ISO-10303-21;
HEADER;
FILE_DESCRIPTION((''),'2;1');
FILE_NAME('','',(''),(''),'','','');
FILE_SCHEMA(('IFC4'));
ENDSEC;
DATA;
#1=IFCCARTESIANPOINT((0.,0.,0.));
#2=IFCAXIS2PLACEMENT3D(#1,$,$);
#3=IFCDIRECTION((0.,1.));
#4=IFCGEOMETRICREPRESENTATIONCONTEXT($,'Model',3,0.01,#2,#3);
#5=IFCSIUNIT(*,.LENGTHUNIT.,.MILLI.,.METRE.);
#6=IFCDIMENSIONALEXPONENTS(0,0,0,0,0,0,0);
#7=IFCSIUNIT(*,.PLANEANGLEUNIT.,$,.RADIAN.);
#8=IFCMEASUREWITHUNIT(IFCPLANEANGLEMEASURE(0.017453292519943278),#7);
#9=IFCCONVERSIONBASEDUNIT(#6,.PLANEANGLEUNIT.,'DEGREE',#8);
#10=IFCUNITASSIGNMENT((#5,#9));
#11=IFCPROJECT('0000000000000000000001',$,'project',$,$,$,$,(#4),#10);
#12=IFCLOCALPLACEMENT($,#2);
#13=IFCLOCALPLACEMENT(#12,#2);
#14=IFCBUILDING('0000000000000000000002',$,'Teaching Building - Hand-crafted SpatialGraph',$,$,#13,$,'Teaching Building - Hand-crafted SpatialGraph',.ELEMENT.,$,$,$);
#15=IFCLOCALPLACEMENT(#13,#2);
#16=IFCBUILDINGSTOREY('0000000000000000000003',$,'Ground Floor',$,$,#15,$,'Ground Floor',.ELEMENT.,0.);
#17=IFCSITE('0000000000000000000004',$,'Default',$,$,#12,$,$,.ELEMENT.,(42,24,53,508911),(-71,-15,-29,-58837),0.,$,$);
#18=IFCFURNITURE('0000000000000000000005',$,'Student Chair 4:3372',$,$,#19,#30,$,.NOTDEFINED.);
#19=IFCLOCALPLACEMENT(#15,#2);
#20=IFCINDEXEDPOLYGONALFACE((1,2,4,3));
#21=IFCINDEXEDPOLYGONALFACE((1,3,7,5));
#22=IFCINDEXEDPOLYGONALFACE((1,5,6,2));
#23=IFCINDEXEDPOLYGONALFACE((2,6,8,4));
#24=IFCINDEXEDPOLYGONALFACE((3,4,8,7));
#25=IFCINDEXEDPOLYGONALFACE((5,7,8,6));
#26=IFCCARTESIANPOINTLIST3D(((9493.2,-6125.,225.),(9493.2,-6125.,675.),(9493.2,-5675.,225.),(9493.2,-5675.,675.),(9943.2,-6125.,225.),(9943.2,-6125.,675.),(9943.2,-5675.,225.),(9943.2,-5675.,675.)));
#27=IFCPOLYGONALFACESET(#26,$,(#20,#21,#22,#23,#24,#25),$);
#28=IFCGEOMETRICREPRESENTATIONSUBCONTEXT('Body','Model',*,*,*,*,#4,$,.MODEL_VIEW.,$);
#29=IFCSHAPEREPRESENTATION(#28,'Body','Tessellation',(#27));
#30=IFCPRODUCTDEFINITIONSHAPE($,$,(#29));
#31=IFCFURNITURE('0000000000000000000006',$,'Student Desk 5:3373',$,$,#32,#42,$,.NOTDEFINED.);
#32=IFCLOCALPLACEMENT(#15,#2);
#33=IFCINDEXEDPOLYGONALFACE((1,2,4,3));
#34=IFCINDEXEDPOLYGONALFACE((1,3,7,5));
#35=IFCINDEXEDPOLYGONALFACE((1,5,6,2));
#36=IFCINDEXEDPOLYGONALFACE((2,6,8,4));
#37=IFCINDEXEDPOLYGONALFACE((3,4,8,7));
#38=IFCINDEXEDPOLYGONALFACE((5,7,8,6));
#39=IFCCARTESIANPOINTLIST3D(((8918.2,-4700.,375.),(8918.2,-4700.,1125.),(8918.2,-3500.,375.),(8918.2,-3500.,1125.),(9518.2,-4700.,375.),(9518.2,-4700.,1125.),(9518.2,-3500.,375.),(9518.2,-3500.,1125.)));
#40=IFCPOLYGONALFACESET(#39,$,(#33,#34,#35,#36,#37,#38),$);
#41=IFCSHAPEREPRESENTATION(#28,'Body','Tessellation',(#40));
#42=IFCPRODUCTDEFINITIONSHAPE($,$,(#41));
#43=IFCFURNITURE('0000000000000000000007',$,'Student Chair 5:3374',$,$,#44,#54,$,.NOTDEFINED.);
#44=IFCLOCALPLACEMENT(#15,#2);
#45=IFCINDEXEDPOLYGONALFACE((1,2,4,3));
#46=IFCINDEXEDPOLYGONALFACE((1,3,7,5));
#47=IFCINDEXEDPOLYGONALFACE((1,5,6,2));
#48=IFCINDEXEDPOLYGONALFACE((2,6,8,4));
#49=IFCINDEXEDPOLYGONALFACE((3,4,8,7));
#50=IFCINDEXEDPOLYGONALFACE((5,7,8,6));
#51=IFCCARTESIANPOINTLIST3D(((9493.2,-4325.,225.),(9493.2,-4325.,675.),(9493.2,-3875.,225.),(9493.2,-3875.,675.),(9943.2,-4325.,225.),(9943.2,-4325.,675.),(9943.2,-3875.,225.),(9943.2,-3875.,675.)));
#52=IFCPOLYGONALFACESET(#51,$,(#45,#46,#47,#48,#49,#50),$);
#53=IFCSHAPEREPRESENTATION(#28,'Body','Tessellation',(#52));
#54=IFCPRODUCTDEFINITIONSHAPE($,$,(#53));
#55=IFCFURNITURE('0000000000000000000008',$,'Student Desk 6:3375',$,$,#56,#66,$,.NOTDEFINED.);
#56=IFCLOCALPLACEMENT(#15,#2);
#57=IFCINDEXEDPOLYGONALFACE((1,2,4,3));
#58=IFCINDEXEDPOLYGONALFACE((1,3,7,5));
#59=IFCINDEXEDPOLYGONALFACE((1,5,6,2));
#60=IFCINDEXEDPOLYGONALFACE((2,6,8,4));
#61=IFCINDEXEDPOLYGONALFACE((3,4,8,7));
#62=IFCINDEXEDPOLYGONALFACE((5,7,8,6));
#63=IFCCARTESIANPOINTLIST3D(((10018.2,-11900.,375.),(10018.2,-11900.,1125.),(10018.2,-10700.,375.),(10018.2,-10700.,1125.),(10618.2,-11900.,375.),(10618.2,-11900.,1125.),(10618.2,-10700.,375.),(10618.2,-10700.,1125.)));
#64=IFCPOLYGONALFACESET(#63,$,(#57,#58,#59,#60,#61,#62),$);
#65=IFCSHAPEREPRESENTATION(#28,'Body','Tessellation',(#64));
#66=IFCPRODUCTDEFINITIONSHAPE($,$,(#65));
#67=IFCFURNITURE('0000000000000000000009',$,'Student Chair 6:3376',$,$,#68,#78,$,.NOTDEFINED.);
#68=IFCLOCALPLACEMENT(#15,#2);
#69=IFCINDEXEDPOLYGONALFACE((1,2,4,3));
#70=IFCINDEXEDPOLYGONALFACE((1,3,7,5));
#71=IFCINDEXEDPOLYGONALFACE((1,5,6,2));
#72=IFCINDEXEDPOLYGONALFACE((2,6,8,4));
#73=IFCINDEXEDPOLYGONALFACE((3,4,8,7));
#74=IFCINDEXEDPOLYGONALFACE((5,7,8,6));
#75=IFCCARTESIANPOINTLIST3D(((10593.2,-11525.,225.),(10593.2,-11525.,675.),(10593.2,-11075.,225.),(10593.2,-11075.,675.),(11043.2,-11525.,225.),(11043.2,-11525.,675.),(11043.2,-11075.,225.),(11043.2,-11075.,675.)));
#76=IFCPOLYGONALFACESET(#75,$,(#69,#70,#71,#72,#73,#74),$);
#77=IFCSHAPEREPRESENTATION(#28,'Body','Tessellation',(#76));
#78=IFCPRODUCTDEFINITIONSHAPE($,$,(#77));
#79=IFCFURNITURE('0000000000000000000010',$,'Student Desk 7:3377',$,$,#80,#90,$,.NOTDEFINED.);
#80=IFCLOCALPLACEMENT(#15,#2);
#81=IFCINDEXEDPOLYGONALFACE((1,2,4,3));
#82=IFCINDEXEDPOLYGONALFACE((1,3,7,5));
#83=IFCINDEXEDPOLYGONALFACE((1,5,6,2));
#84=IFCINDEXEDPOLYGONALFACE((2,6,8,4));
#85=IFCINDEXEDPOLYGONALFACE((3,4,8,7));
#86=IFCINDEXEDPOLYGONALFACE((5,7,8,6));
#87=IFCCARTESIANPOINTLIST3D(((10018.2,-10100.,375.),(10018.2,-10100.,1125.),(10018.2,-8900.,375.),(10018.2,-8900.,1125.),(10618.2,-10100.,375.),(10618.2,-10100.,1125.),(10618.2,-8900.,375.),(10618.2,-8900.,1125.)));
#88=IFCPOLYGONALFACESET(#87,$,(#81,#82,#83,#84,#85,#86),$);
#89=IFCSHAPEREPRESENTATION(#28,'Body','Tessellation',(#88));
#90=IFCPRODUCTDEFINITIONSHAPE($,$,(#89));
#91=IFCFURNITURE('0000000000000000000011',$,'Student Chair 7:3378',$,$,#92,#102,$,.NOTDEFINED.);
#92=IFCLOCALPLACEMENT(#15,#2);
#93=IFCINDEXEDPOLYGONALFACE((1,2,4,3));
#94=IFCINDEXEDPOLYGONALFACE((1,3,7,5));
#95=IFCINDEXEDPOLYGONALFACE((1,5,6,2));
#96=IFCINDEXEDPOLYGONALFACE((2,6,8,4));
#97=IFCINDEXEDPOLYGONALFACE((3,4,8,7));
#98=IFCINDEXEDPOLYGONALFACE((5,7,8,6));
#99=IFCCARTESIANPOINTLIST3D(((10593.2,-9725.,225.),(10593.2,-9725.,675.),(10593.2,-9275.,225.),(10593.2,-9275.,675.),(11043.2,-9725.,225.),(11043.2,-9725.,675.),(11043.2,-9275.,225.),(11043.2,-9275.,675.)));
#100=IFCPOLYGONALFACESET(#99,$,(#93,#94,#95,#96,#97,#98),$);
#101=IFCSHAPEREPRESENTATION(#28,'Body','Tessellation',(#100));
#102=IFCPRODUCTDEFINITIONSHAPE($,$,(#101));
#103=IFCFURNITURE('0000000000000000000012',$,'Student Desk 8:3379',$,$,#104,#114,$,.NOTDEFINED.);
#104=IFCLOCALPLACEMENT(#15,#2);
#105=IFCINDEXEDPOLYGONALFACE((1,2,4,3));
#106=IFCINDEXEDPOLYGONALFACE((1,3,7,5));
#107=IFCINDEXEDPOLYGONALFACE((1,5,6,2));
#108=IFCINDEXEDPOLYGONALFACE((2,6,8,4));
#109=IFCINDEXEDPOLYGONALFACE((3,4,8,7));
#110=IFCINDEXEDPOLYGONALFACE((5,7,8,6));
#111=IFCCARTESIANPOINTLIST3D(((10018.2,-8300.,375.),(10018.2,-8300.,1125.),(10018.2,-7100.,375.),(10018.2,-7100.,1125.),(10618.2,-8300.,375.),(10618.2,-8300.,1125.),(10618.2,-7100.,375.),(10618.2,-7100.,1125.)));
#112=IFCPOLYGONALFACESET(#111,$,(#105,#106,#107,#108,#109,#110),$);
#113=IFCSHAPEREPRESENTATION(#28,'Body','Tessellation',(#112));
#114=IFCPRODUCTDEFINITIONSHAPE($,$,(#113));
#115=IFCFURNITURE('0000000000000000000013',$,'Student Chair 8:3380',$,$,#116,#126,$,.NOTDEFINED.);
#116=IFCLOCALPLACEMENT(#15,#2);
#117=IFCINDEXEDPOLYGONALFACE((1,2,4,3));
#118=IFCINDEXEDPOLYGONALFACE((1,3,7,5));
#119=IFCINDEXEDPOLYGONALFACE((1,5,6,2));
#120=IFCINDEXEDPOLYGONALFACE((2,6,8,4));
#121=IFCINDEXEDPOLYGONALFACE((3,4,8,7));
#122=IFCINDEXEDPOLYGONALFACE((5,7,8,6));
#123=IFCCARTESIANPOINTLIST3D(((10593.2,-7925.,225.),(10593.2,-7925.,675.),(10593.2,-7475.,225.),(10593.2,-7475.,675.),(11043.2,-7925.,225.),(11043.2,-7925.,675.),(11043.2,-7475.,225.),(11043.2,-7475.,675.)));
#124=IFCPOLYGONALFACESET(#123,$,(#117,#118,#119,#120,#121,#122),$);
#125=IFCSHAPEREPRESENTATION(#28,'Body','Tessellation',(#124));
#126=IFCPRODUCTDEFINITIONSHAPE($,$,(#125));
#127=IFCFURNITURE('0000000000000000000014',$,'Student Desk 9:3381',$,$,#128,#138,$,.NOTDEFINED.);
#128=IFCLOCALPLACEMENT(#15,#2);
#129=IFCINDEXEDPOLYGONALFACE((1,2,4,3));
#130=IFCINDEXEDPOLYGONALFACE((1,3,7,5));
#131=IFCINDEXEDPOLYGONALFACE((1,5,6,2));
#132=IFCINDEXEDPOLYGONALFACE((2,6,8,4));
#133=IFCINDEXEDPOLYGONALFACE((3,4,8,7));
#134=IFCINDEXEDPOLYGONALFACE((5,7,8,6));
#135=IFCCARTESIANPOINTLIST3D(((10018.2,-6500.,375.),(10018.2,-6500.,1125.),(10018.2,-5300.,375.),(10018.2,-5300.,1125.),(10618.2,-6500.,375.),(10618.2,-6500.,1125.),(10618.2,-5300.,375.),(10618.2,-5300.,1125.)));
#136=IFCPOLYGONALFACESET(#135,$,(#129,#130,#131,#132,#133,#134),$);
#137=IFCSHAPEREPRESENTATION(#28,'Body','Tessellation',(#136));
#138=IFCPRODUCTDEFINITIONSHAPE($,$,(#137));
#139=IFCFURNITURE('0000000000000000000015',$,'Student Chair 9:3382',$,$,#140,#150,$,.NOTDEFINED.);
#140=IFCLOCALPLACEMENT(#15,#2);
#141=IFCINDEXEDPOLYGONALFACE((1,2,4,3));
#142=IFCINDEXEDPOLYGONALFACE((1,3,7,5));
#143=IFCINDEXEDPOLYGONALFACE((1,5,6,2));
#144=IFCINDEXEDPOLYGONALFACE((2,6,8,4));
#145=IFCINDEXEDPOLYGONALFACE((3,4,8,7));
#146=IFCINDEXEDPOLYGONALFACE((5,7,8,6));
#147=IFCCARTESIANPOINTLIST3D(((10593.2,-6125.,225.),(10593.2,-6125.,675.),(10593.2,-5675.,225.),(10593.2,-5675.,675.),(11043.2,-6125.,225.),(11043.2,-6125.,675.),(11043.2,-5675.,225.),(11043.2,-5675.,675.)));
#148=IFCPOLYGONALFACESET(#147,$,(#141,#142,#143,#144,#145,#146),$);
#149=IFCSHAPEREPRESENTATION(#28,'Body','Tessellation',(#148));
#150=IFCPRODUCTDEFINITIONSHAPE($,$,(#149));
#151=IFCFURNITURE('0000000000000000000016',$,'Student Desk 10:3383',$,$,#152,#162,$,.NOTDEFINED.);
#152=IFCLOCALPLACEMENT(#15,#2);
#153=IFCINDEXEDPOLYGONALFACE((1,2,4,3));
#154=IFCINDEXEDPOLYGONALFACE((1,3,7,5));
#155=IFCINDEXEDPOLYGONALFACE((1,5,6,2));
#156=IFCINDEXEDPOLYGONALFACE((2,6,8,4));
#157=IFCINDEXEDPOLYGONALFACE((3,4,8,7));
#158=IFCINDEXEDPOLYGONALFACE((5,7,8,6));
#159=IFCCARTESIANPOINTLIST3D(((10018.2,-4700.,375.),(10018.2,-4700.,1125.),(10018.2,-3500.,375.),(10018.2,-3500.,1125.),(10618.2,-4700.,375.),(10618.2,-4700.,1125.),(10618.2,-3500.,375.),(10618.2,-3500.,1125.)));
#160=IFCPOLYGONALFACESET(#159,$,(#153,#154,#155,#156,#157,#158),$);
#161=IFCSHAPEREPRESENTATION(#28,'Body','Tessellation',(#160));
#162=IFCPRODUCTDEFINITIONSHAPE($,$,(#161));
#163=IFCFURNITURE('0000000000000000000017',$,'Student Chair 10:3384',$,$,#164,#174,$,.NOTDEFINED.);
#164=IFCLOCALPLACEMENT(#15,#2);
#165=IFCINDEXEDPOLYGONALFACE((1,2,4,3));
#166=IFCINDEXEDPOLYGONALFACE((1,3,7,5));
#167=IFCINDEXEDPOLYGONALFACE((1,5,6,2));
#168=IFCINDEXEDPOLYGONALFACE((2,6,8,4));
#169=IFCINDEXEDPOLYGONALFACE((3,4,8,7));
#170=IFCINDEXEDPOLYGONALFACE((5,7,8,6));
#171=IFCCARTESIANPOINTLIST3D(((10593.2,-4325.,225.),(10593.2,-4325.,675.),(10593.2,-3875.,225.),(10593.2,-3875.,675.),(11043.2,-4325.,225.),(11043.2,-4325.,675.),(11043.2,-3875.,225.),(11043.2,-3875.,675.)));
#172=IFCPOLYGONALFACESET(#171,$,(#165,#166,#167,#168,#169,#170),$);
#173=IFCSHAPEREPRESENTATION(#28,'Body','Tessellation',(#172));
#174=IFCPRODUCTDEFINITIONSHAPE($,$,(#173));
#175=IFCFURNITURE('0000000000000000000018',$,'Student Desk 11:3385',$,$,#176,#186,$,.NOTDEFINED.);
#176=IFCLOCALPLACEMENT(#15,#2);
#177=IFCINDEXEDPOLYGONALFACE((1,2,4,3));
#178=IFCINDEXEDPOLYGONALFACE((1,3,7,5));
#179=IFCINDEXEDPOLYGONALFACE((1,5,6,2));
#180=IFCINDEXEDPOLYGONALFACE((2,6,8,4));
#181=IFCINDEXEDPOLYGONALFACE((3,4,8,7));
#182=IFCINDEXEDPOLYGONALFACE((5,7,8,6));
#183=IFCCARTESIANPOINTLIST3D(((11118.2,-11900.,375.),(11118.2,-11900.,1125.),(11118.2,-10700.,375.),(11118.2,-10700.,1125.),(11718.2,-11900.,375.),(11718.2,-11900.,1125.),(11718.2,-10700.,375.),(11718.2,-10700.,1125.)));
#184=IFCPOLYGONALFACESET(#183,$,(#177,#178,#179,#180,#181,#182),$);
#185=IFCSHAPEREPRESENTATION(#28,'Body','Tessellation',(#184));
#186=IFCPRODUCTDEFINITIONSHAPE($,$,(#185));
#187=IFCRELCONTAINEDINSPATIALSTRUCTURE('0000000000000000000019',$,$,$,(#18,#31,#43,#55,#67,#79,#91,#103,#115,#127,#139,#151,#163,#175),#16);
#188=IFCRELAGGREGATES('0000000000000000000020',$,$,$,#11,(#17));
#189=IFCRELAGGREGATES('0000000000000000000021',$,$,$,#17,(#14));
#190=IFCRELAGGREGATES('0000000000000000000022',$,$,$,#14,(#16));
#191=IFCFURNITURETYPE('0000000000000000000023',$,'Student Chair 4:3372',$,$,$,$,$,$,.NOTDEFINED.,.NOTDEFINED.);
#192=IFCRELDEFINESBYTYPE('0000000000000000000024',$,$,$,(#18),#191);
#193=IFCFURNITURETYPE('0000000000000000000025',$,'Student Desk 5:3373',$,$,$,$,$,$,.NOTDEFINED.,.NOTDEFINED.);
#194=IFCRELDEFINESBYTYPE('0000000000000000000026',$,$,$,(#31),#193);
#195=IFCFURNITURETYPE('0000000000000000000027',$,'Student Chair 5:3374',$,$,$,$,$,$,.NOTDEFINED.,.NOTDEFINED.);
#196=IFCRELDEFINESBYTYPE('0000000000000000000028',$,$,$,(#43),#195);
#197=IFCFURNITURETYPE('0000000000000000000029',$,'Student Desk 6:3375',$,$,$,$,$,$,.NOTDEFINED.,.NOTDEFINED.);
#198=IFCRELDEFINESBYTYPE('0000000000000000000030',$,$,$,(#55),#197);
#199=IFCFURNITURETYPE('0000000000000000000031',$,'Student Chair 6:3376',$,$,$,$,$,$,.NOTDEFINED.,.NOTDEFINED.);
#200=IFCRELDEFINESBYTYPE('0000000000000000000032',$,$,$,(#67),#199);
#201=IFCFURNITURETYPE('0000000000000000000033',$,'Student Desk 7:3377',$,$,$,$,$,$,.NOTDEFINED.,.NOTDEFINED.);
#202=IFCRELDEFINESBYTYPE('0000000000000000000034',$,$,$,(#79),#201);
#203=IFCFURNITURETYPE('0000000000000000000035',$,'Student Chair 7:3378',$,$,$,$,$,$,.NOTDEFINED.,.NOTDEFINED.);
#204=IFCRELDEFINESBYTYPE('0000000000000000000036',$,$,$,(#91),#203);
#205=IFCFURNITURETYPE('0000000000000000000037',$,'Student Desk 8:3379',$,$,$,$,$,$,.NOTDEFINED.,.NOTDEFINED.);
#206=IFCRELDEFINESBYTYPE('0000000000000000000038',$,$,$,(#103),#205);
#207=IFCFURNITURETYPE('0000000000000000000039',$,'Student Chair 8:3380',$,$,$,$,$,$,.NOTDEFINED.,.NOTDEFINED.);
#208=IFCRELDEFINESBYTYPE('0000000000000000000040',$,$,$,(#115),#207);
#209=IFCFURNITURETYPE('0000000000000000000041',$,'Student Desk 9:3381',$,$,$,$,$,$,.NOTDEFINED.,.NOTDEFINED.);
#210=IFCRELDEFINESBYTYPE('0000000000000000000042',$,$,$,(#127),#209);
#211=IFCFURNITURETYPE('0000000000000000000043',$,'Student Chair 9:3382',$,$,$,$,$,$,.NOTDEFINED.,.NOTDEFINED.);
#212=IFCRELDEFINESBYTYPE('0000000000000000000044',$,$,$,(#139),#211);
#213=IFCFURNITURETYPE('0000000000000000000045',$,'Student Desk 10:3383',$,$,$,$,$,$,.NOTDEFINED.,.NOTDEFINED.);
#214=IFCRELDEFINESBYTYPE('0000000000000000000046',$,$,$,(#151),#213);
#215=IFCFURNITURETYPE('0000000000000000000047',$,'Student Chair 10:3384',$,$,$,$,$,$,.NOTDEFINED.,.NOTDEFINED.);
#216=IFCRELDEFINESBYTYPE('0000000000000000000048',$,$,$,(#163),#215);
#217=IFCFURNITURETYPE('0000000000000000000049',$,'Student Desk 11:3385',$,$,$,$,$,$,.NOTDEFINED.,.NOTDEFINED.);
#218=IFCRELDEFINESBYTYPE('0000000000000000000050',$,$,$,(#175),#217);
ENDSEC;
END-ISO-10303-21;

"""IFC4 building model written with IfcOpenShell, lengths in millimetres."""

from ifc_helpers import new_model, entity, si_unit, converted_unit, direction, frame, frame_2d, origin, origin_2d_with_axis, place, context, subcontext, project, spatial, rectangle, extrude, type_object, element, save


model = new_model("IFC4")

# Units and contexts
model_context = context("Model", 3, precision=0.01, world=origin(), true_north=direction((0.0, 1.0)))
body_context = subcontext(model_context, "Body", "Model", "MODEL_VIEW")
ifc_project = project(units=[si_unit("LENGTHUNIT", "METRE", prefix="MILLI"), converted_unit("PLANEANGLEUNIT", "DEGREE", entity("IfcPlaneAngleMeasure", 0.017453292519943278), si_unit("PLANEANGLEUNIT", "RADIAN"), dimensions=[0, 0, 0, 0, 0, 0, 0])], contexts=[model_context])

# Site, building, storey
site_placement = place(None, origin())
site = spatial("IfcSite", under=ifc_project, at=site_placement, Name="Default", CompositionType="ELEMENT", RefLatitude=(42, 24, 53, 508911), RefLongitude=(-71, -15, -29, -58837), RefElevation=0.0)
building_placement = place(site_placement, origin())
building = spatial("IfcBuilding", under=site, at=building_placement, Name="Teaching Building - Hand-crafted SpatialGraph", LongName="Teaching Building - Hand-crafted SpatialGraph", CompositionType="ELEMENT")
storey_placement = place(building_placement, origin())
storey = spatial("IfcBuildingStorey", under=building, at=storey_placement, Name="Ground Floor", LongName="Ground Floor", CompositionType="ELEMENT", Elevation=0.0)

# Furniture
furniture_type_1 = type_object("IfcFurnitureType", Name="Student Chair 4:3372", PredefinedType="NOTDEFINED")
furniture_1_placement = place(storey_placement, origin())
element("IfcFurniture", 1, at=furniture_1_placement, inside=storey, type_object=furniture_type_1, Name="Student Chair 4:3372", PredefinedType="NOTDEFINED", context=body_context, shape_type="SweptSolid", body=[
    extrude(rectangle(XDim=450.0, YDim=450.0, at=frame_2d((0.0, 0.0), x_axis=(1.0, 0.0))), frame((9718.2, -5900.0, 225.0)), (0.0, 0.0, 1.0), 450.0),
])
furniture_type_2 = type_object("IfcFurnitureType", Name="Student Desk 5:3373", PredefinedType="NOTDEFINED")
furniture_2_placement = place(storey_placement, origin())
element("IfcFurniture", 2, at=furniture_2_placement, inside=storey, type_object=furniture_type_2, Name="Student Desk 5:3373", PredefinedType="NOTDEFINED", context=body_context, shape_type="SweptSolid", body=[
    extrude(rectangle(XDim=1200.0, YDim=600.0, at=frame_2d((0.0, 0.0), x_axis=(1.0, 0.0))), frame((9218.2, -4100.0, 375.0), z_axis=(0.0, 0.0, 1.0), x_axis=(0.0, 1.0, 0.0)), (0.0, 0.0, 1.0), 750.0),
])
furniture_type_3 = type_object("IfcFurnitureType", Name="Student Chair 5:3374", PredefinedType="NOTDEFINED")
furniture_3_placement = place(storey_placement, origin())
element("IfcFurniture", 3, at=furniture_3_placement, inside=storey, type_object=furniture_type_3, Name="Student Chair 5:3374", PredefinedType="NOTDEFINED", context=body_context, shape_type="SweptSolid", body=[
    extrude(rectangle(XDim=450.0, YDim=450.0, at=frame_2d((0.0, 0.0), x_axis=(1.0, 0.0))), frame((9718.2, -4100.0, 225.0)), (0.0, 0.0, 1.0), 450.0),
])
furniture_type_4 = type_object("IfcFurnitureType", Name="Student Desk 6:3375", PredefinedType="NOTDEFINED")
furniture_4_placement = place(storey_placement, origin())
element("IfcFurniture", 4, at=furniture_4_placement, inside=storey, type_object=furniture_type_4, Name="Student Desk 6:3375", PredefinedType="NOTDEFINED", context=body_context, shape_type="SweptSolid", body=[
    extrude(rectangle(XDim=1200.0, YDim=600.0, at=origin_2d_with_axis()), frame((10318.2, -11300.0, 375.0), z_axis=(0.0, 0.0, 1.0), x_axis=(0.0, 1.0, 0.0)), (0.0, 0.0, 1.0), 750.0),
])
furniture_type_5 = type_object("IfcFurnitureType", Name="Student Chair 6:3376", PredefinedType="NOTDEFINED")
furniture_5_placement = place(storey_placement, origin())
element("IfcFurniture", 5, at=furniture_5_placement, inside=storey, type_object=furniture_type_5, Name="Student Chair 6:3376", PredefinedType="NOTDEFINED", context=body_context, shape_type="SweptSolid", body=[
    extrude(rectangle(XDim=450.0, YDim=450.0, at=origin_2d_with_axis()), frame((10818.2, -11300.0, 225.0)), (0.0, 0.0, 1.0), 450.0),
])
furniture_type_6 = type_object("IfcFurnitureType", Name="Student Desk 7:3377", PredefinedType="NOTDEFINED")
furniture_6_placement = place(storey_placement, origin())
element("IfcFurniture", 6, at=furniture_6_placement, inside=storey, type_object=furniture_type_6, Name="Student Desk 7:3377", PredefinedType="NOTDEFINED", context=body_context, shape_type="SweptSolid", body=[
    extrude(rectangle(XDim=1200.0, YDim=600.0, at=origin_2d_with_axis()), frame((10318.2, -9500.0, 375.0), z_axis=(0.0, 0.0, 1.0), x_axis=(0.0, 1.0, 0.0)), (0.0, 0.0, 1.0), 750.0),
])
furniture_type_7 = type_object("IfcFurnitureType", Name="Student Chair 7:3378", PredefinedType="NOTDEFINED")
furniture_7_placement = place(storey_placement, origin())
element("IfcFurniture", 7, at=furniture_7_placement, inside=storey, type_object=furniture_type_7, Name="Student Chair 7:3378", PredefinedType="NOTDEFINED", context=body_context, shape_type="SweptSolid", body=[
    extrude(rectangle(XDim=450.0, YDim=450.0, at=origin_2d_with_axis()), frame((10818.2, -9500.0, 225.0)), (0.0, 0.0, 1.0), 450.0),
])
furniture_type_8 = type_object("IfcFurnitureType", Name="Student Desk 8:3379", PredefinedType="NOTDEFINED")
furniture_8_placement = place(storey_placement, origin())
element("IfcFurniture", 8, at=furniture_8_placement, inside=storey, type_object=furniture_type_8, Name="Student Desk 8:3379", PredefinedType="NOTDEFINED", context=body_context, shape_type="SweptSolid", body=[
    extrude(rectangle(XDim=1200.0, YDim=600.0, at=origin_2d_with_axis()), frame((10318.2, -7700.0, 375.0), z_axis=(0.0, 0.0, 1.0), x_axis=(0.0, 1.0, 0.0)), (0.0, 0.0, 1.0), 750.0),
])
furniture_type_9 = type_object("IfcFurnitureType", Name="Student Chair 8:3380", PredefinedType="NOTDEFINED")
furniture_9_placement = place(storey_placement, origin())
element("IfcFurniture", 9, at=furniture_9_placement, inside=storey, type_object=furniture_type_9, Name="Student Chair 8:3380", PredefinedType="NOTDEFINED", context=body_context, shape_type="SweptSolid", body=[
    extrude(rectangle(XDim=450.0, YDim=450.0, at=frame_2d((0.0, 0.0), x_axis=(1.0, 0.0))), frame((10818.2, -7700.0, 225.0)), (0.0, 0.0, 1.0), 450.0),
])
furniture_type_10 = type_object("IfcFurnitureType", Name="Student Desk 9:3381", PredefinedType="NOTDEFINED")
furniture_10_placement = place(storey_placement, origin())
element("IfcFurniture", 10, at=furniture_10_placement, inside=storey, type_object=furniture_type_10, Name="Student Desk 9:3381", PredefinedType="NOTDEFINED", context=body_context, shape_type="SweptSolid", body=[
    extrude(rectangle(XDim=1200.0, YDim=600.0, at=origin_2d_with_axis()), frame((10318.2, -5900.0, 375.0), z_axis=(0.0, 0.0, 1.0), x_axis=(0.0, 1.0, 0.0)), (0.0, 0.0, 1.0), 750.0),
])
furniture_type_11 = type_object("IfcFurnitureType", Name="Student Chair 9:3382", PredefinedType="NOTDEFINED")
furniture_11_placement = place(storey_placement, origin())
element("IfcFurniture", 11, at=furniture_11_placement, inside=storey, type_object=furniture_type_11, Name="Student Chair 9:3382", PredefinedType="NOTDEFINED", context=body_context, shape_type="SweptSolid", body=[
    extrude(rectangle(XDim=450.0, YDim=450.0, at=origin_2d_with_axis()), frame((10818.2, -5900.0, 225.0)), (0.0, 0.0, 1.0), 450.0),
])
furniture_type_12 = type_object("IfcFurnitureType", Name="Student Desk 10:3383", PredefinedType="NOTDEFINED")
furniture_12_placement = place(storey_placement, origin())
element("IfcFurniture", 12, at=furniture_12_placement, inside=storey, type_object=furniture_type_12, Name="Student Desk 10:3383", PredefinedType="NOTDEFINED", context=body_context, shape_type="SweptSolid", body=[
    extrude(rectangle(XDim=1200.0, YDim=600.0, at=origin_2d_with_axis()), frame((10318.2, -4100.0, 375.0), z_axis=(0.0, 0.0, 1.0), x_axis=(0.0, 1.0, 0.0)), (0.0, 0.0, 1.0), 750.0),
])
furniture_type_13 = type_object("IfcFurnitureType", Name="Student Chair 10:3384", PredefinedType="NOTDEFINED")
furniture_13_placement = place(storey_placement, origin())
element("IfcFurniture", 13, at=furniture_13_placement, inside=storey, type_object=furniture_type_13, Name="Student Chair 10:3384", PredefinedType="NOTDEFINED", context=body_context, shape_type="SweptSolid", body=[
    extrude(rectangle(XDim=450.0, YDim=450.0, at=origin_2d_with_axis()), frame((10818.2, -4100.0, 225.0)), (0.0, 0.0, 1.0), 450.0),
])
furniture_type_14 = type_object("IfcFurnitureType", Name="Student Desk 11:3385", PredefinedType="NOTDEFINED")
furniture_14_placement = place(storey_placement, origin())
element("IfcFurniture", 14, at=furniture_14_placement, inside=storey, type_object=furniture_type_14, Name="Student Desk 11:3385", PredefinedType="NOTDEFINED", context=body_context, shape_type="SweptSolid", body=[
    extrude(rectangle(XDim=1200.0, YDim=600.0, at=origin_2d_with_axis()), frame((11418.2, -11300.0, 375.0), z_axis=(0.0, 0.0, 1.0), x_axis=(0.0, 1.0, 0.0)), (0.0, 0.0, 1.0), 750.0),
])

save(model, "model.ifc")
